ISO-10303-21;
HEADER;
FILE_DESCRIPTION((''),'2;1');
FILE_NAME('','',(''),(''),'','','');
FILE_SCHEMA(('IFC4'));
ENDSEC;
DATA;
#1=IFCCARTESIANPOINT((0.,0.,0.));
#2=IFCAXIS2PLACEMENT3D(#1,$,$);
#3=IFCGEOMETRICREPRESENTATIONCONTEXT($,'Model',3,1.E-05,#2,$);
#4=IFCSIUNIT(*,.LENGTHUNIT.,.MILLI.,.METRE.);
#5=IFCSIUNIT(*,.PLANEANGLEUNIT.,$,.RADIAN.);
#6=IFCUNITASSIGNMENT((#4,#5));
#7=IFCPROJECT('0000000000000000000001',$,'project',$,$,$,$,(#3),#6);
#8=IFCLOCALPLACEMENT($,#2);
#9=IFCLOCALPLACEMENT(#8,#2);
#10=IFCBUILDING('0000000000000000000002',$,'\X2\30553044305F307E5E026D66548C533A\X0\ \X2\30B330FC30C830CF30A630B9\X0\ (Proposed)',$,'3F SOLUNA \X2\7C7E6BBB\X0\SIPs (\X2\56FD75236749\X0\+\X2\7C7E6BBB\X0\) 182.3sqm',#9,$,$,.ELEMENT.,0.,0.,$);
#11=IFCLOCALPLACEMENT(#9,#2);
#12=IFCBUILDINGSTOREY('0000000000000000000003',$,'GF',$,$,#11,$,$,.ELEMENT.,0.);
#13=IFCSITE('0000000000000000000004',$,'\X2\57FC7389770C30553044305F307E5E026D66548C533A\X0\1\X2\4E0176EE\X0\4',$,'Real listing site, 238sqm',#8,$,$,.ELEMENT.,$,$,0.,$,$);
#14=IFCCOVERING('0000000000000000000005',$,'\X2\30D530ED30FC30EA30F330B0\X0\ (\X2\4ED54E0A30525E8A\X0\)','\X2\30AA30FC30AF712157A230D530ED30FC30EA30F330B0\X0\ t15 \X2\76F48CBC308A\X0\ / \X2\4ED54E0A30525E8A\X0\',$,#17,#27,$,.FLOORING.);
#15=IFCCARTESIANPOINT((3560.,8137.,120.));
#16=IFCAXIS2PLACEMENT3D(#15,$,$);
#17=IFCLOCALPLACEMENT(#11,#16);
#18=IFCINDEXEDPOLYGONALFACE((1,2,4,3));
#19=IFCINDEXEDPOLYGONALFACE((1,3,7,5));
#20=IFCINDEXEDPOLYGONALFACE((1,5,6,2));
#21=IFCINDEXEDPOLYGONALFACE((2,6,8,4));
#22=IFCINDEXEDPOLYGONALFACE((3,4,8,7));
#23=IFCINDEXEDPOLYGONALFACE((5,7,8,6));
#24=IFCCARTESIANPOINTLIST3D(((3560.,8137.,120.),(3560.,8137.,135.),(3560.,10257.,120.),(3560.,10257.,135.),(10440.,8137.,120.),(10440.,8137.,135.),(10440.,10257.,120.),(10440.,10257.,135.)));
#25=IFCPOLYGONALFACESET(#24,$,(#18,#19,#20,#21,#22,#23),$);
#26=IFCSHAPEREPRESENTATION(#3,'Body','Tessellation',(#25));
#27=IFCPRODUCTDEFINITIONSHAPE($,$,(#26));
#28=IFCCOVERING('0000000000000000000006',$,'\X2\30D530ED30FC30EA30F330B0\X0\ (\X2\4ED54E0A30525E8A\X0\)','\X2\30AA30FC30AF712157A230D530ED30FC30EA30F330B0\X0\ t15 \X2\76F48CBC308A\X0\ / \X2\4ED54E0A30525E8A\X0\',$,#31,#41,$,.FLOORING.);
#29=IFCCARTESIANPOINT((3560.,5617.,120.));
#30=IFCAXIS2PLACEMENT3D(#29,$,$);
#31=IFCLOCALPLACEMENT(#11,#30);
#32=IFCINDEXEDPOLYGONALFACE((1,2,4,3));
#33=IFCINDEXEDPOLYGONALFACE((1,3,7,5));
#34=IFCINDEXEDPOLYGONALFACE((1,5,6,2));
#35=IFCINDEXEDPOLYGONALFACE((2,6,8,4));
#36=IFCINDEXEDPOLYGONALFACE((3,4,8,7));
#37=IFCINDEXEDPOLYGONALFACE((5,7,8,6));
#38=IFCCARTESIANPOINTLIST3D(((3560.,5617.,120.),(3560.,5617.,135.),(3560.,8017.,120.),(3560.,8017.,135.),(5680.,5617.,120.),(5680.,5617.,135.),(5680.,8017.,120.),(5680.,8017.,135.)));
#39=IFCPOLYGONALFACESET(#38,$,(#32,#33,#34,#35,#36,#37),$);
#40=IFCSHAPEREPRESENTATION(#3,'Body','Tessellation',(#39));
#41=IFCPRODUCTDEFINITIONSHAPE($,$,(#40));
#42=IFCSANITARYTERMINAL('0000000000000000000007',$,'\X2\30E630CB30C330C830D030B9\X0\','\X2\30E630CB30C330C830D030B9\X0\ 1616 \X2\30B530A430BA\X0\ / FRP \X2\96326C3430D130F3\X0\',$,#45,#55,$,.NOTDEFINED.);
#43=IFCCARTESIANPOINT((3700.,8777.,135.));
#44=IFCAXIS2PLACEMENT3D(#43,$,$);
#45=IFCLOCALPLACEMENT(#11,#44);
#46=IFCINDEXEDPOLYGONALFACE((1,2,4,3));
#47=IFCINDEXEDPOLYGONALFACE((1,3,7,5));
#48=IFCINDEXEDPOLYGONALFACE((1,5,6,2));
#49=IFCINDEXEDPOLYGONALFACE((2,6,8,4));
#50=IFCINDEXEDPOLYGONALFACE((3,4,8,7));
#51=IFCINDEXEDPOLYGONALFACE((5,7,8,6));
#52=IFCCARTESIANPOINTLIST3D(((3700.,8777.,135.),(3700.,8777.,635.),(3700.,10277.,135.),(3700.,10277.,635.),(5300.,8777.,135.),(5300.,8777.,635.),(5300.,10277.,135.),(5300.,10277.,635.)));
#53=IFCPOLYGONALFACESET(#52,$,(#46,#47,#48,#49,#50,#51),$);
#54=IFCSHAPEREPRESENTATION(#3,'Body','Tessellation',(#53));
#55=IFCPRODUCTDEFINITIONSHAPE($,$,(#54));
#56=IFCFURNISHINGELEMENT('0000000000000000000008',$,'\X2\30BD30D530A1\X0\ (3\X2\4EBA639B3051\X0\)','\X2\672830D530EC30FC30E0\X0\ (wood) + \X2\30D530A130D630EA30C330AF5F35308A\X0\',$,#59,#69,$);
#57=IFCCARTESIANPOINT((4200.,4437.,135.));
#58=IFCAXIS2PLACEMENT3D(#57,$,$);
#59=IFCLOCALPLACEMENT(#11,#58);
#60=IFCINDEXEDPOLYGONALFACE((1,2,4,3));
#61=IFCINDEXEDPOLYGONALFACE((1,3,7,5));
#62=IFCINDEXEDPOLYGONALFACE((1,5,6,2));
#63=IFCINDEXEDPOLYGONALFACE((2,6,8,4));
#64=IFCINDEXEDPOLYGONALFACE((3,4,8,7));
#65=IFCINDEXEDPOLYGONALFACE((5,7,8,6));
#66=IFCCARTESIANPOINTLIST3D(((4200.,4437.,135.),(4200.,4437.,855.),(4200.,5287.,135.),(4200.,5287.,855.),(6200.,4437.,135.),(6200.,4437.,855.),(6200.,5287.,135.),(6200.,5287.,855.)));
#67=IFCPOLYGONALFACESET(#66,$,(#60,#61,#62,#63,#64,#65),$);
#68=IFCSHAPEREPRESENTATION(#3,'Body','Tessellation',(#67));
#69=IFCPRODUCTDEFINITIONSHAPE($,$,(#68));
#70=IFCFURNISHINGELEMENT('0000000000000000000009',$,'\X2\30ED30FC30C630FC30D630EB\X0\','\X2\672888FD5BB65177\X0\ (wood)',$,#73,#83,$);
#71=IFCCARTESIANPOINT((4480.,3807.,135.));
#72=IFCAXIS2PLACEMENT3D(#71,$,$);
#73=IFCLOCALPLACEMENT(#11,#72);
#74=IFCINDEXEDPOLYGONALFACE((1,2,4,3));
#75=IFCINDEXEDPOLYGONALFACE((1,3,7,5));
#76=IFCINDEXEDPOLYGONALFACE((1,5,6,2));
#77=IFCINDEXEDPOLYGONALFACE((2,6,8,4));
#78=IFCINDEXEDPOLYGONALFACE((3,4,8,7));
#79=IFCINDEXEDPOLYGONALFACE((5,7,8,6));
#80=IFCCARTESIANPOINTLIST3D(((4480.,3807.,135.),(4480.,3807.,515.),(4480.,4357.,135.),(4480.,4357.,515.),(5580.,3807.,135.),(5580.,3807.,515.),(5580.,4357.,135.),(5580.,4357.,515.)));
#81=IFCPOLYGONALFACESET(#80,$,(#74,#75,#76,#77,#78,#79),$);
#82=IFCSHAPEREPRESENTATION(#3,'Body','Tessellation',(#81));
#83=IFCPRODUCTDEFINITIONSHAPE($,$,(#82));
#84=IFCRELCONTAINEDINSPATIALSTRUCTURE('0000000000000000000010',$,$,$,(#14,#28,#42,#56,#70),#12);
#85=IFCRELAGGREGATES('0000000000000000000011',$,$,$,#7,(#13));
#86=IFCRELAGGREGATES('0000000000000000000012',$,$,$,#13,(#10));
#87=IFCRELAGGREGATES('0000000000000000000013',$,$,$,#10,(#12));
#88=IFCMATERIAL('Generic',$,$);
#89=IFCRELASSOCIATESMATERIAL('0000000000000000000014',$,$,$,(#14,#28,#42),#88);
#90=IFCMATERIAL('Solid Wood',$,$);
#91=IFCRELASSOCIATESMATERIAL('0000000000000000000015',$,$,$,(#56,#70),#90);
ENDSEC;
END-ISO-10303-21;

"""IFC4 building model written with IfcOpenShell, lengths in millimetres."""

from ifc_helpers import new_model, si_unit, frame, frame_2d, origin, place, context, project, spatial, rectangle, extrude, material, element, save


model = new_model("IFC4")

# Units and contexts
model_context = context("Model", 3, precision=1e-05, world=origin())
ifc_project = project(units=[si_unit("LENGTHUNIT", "METRE", prefix="MILLI"), si_unit("PLANEANGLEUNIT", "RADIAN")], contexts=[model_context])

# Site, building, storey
site_placement = place(None, origin())
site = spatial("IfcSite", under=ifc_project, at=site_placement, Name="埼玉県さいたま市浦和区1丁目4", ObjectType="Real listing site, 238sqm", CompositionType="ELEMENT", RefElevation=0.0)
building_placement = place(site_placement, origin())
building = spatial("IfcBuilding", under=site, at=building_placement, Name="さいたま市浦和区 コートハウス (Proposed)", ObjectType="3F SOLUNA 籾殻SIPs (国産杉+籾殻) 182.3sqm", CompositionType="ELEMENT", ElevationOfRefHeight=0.0, ElevationOfTerrain=0.0)
storey_placement = place(building_placement, origin())
storey = spatial("IfcBuildingStorey", under=building, at=storey_placement, Name="GF", CompositionType="ELEMENT", Elevation=0.0)

# Shared definitions
ifc_material_1 = material(Name="Solid Wood")

# Coverings
ifc_material_2 = material(Name="Generic")
covering_1_placement = place(storey_placement, frame((3560.0, 8137.0, 120.0)))
element("IfcCovering", 1, at=covering_1_placement, inside=storey, material=ifc_material_2, Name="フローリング (仕上げ床)", Description="オーク無垢フローリング t15 直貼り / 仕上げ床", PredefinedType="FLOORING", context=model_context, shape_type="SweptSolid", body=[
    extrude(rectangle(XDim=6880.0, YDim=2120.0, at=frame_2d((3440.0, 1060.0))), frame((3560.0, 8137.0, 120.0)), (0.0, 0.0, 1.0), 15.0),
])
covering_2_placement = place(storey_placement, frame((3560.0, 5617.0, 120.0)))
element("IfcCovering", 2, at=covering_2_placement, inside=storey, material=ifc_material_2, Name="フローリング (仕上げ床)", Description="オーク無垢フローリング t15 直貼り / 仕上げ床", PredefinedType="FLOORING", context=model_context, shape_type="SweptSolid", body=[
    extrude(rectangle(XDim=2120.0, YDim=2400.0, at=frame_2d((1060.0, 1200.0))), frame((3560.0, 5617.0, 120.0)), (0.0, 0.0, 1.0), 15.0),
])

# Sanitary terminal
sanitary_terminal_placement = place(storey_placement, frame((3700.0, 8777.0, 135.0)))
element("IfcSanitaryTerminal", 3, at=sanitary_terminal_placement, inside=storey, material=ifc_material_2, Name="ユニットバス", Description="ユニットバス 1616 サイズ / FRP 防水パン", PredefinedType="NOTDEFINED", context=model_context, shape_type="SweptSolid", body=[
    extrude(rectangle(XDim=1600.0, YDim=1500.0, at=frame_2d((800.0, 750.0))), frame((3700.0, 8777.0, 135.0)), (0.0, 0.0, 1.0), 500.0),
])

# Furnishing elements
furnishing_1_placement = place(storey_placement, frame((4200.0, 4437.0, 135.0)))
element("IfcFurnishingElement", 4, at=furnishing_1_placement, inside=storey, material=ifc_material_1, Name="ソファ (3人掛け)", Description="木フレーム (wood) + ファブリック張り", context=model_context, shape_type="SweptSolid", body=[
    extrude(rectangle(XDim=2000.0, YDim=850.0, at=frame_2d((1000.0, 425.0))), frame((4200.0, 4437.0, 135.0)), (0.0, 0.0, 1.0), 720.0),
])
furnishing_2_placement = place(storey_placement, frame((4480.0, 3807.0, 135.0)))
element("IfcFurnishingElement", 5, at=furnishing_2_placement, inside=storey, material=ifc_material_1, Name="ローテーブル", Description="木製家具 (wood)", context=model_context, shape_type="SweptSolid", body=[
    extrude(rectangle(XDim=1100.0, YDim=550.0, at=frame_2d((550.0, 275.0))), frame((4480.0, 3807.0, 135.0)), (0.0, 0.0, 1.0), 380.0),
])

save(model, "model.ifc")
